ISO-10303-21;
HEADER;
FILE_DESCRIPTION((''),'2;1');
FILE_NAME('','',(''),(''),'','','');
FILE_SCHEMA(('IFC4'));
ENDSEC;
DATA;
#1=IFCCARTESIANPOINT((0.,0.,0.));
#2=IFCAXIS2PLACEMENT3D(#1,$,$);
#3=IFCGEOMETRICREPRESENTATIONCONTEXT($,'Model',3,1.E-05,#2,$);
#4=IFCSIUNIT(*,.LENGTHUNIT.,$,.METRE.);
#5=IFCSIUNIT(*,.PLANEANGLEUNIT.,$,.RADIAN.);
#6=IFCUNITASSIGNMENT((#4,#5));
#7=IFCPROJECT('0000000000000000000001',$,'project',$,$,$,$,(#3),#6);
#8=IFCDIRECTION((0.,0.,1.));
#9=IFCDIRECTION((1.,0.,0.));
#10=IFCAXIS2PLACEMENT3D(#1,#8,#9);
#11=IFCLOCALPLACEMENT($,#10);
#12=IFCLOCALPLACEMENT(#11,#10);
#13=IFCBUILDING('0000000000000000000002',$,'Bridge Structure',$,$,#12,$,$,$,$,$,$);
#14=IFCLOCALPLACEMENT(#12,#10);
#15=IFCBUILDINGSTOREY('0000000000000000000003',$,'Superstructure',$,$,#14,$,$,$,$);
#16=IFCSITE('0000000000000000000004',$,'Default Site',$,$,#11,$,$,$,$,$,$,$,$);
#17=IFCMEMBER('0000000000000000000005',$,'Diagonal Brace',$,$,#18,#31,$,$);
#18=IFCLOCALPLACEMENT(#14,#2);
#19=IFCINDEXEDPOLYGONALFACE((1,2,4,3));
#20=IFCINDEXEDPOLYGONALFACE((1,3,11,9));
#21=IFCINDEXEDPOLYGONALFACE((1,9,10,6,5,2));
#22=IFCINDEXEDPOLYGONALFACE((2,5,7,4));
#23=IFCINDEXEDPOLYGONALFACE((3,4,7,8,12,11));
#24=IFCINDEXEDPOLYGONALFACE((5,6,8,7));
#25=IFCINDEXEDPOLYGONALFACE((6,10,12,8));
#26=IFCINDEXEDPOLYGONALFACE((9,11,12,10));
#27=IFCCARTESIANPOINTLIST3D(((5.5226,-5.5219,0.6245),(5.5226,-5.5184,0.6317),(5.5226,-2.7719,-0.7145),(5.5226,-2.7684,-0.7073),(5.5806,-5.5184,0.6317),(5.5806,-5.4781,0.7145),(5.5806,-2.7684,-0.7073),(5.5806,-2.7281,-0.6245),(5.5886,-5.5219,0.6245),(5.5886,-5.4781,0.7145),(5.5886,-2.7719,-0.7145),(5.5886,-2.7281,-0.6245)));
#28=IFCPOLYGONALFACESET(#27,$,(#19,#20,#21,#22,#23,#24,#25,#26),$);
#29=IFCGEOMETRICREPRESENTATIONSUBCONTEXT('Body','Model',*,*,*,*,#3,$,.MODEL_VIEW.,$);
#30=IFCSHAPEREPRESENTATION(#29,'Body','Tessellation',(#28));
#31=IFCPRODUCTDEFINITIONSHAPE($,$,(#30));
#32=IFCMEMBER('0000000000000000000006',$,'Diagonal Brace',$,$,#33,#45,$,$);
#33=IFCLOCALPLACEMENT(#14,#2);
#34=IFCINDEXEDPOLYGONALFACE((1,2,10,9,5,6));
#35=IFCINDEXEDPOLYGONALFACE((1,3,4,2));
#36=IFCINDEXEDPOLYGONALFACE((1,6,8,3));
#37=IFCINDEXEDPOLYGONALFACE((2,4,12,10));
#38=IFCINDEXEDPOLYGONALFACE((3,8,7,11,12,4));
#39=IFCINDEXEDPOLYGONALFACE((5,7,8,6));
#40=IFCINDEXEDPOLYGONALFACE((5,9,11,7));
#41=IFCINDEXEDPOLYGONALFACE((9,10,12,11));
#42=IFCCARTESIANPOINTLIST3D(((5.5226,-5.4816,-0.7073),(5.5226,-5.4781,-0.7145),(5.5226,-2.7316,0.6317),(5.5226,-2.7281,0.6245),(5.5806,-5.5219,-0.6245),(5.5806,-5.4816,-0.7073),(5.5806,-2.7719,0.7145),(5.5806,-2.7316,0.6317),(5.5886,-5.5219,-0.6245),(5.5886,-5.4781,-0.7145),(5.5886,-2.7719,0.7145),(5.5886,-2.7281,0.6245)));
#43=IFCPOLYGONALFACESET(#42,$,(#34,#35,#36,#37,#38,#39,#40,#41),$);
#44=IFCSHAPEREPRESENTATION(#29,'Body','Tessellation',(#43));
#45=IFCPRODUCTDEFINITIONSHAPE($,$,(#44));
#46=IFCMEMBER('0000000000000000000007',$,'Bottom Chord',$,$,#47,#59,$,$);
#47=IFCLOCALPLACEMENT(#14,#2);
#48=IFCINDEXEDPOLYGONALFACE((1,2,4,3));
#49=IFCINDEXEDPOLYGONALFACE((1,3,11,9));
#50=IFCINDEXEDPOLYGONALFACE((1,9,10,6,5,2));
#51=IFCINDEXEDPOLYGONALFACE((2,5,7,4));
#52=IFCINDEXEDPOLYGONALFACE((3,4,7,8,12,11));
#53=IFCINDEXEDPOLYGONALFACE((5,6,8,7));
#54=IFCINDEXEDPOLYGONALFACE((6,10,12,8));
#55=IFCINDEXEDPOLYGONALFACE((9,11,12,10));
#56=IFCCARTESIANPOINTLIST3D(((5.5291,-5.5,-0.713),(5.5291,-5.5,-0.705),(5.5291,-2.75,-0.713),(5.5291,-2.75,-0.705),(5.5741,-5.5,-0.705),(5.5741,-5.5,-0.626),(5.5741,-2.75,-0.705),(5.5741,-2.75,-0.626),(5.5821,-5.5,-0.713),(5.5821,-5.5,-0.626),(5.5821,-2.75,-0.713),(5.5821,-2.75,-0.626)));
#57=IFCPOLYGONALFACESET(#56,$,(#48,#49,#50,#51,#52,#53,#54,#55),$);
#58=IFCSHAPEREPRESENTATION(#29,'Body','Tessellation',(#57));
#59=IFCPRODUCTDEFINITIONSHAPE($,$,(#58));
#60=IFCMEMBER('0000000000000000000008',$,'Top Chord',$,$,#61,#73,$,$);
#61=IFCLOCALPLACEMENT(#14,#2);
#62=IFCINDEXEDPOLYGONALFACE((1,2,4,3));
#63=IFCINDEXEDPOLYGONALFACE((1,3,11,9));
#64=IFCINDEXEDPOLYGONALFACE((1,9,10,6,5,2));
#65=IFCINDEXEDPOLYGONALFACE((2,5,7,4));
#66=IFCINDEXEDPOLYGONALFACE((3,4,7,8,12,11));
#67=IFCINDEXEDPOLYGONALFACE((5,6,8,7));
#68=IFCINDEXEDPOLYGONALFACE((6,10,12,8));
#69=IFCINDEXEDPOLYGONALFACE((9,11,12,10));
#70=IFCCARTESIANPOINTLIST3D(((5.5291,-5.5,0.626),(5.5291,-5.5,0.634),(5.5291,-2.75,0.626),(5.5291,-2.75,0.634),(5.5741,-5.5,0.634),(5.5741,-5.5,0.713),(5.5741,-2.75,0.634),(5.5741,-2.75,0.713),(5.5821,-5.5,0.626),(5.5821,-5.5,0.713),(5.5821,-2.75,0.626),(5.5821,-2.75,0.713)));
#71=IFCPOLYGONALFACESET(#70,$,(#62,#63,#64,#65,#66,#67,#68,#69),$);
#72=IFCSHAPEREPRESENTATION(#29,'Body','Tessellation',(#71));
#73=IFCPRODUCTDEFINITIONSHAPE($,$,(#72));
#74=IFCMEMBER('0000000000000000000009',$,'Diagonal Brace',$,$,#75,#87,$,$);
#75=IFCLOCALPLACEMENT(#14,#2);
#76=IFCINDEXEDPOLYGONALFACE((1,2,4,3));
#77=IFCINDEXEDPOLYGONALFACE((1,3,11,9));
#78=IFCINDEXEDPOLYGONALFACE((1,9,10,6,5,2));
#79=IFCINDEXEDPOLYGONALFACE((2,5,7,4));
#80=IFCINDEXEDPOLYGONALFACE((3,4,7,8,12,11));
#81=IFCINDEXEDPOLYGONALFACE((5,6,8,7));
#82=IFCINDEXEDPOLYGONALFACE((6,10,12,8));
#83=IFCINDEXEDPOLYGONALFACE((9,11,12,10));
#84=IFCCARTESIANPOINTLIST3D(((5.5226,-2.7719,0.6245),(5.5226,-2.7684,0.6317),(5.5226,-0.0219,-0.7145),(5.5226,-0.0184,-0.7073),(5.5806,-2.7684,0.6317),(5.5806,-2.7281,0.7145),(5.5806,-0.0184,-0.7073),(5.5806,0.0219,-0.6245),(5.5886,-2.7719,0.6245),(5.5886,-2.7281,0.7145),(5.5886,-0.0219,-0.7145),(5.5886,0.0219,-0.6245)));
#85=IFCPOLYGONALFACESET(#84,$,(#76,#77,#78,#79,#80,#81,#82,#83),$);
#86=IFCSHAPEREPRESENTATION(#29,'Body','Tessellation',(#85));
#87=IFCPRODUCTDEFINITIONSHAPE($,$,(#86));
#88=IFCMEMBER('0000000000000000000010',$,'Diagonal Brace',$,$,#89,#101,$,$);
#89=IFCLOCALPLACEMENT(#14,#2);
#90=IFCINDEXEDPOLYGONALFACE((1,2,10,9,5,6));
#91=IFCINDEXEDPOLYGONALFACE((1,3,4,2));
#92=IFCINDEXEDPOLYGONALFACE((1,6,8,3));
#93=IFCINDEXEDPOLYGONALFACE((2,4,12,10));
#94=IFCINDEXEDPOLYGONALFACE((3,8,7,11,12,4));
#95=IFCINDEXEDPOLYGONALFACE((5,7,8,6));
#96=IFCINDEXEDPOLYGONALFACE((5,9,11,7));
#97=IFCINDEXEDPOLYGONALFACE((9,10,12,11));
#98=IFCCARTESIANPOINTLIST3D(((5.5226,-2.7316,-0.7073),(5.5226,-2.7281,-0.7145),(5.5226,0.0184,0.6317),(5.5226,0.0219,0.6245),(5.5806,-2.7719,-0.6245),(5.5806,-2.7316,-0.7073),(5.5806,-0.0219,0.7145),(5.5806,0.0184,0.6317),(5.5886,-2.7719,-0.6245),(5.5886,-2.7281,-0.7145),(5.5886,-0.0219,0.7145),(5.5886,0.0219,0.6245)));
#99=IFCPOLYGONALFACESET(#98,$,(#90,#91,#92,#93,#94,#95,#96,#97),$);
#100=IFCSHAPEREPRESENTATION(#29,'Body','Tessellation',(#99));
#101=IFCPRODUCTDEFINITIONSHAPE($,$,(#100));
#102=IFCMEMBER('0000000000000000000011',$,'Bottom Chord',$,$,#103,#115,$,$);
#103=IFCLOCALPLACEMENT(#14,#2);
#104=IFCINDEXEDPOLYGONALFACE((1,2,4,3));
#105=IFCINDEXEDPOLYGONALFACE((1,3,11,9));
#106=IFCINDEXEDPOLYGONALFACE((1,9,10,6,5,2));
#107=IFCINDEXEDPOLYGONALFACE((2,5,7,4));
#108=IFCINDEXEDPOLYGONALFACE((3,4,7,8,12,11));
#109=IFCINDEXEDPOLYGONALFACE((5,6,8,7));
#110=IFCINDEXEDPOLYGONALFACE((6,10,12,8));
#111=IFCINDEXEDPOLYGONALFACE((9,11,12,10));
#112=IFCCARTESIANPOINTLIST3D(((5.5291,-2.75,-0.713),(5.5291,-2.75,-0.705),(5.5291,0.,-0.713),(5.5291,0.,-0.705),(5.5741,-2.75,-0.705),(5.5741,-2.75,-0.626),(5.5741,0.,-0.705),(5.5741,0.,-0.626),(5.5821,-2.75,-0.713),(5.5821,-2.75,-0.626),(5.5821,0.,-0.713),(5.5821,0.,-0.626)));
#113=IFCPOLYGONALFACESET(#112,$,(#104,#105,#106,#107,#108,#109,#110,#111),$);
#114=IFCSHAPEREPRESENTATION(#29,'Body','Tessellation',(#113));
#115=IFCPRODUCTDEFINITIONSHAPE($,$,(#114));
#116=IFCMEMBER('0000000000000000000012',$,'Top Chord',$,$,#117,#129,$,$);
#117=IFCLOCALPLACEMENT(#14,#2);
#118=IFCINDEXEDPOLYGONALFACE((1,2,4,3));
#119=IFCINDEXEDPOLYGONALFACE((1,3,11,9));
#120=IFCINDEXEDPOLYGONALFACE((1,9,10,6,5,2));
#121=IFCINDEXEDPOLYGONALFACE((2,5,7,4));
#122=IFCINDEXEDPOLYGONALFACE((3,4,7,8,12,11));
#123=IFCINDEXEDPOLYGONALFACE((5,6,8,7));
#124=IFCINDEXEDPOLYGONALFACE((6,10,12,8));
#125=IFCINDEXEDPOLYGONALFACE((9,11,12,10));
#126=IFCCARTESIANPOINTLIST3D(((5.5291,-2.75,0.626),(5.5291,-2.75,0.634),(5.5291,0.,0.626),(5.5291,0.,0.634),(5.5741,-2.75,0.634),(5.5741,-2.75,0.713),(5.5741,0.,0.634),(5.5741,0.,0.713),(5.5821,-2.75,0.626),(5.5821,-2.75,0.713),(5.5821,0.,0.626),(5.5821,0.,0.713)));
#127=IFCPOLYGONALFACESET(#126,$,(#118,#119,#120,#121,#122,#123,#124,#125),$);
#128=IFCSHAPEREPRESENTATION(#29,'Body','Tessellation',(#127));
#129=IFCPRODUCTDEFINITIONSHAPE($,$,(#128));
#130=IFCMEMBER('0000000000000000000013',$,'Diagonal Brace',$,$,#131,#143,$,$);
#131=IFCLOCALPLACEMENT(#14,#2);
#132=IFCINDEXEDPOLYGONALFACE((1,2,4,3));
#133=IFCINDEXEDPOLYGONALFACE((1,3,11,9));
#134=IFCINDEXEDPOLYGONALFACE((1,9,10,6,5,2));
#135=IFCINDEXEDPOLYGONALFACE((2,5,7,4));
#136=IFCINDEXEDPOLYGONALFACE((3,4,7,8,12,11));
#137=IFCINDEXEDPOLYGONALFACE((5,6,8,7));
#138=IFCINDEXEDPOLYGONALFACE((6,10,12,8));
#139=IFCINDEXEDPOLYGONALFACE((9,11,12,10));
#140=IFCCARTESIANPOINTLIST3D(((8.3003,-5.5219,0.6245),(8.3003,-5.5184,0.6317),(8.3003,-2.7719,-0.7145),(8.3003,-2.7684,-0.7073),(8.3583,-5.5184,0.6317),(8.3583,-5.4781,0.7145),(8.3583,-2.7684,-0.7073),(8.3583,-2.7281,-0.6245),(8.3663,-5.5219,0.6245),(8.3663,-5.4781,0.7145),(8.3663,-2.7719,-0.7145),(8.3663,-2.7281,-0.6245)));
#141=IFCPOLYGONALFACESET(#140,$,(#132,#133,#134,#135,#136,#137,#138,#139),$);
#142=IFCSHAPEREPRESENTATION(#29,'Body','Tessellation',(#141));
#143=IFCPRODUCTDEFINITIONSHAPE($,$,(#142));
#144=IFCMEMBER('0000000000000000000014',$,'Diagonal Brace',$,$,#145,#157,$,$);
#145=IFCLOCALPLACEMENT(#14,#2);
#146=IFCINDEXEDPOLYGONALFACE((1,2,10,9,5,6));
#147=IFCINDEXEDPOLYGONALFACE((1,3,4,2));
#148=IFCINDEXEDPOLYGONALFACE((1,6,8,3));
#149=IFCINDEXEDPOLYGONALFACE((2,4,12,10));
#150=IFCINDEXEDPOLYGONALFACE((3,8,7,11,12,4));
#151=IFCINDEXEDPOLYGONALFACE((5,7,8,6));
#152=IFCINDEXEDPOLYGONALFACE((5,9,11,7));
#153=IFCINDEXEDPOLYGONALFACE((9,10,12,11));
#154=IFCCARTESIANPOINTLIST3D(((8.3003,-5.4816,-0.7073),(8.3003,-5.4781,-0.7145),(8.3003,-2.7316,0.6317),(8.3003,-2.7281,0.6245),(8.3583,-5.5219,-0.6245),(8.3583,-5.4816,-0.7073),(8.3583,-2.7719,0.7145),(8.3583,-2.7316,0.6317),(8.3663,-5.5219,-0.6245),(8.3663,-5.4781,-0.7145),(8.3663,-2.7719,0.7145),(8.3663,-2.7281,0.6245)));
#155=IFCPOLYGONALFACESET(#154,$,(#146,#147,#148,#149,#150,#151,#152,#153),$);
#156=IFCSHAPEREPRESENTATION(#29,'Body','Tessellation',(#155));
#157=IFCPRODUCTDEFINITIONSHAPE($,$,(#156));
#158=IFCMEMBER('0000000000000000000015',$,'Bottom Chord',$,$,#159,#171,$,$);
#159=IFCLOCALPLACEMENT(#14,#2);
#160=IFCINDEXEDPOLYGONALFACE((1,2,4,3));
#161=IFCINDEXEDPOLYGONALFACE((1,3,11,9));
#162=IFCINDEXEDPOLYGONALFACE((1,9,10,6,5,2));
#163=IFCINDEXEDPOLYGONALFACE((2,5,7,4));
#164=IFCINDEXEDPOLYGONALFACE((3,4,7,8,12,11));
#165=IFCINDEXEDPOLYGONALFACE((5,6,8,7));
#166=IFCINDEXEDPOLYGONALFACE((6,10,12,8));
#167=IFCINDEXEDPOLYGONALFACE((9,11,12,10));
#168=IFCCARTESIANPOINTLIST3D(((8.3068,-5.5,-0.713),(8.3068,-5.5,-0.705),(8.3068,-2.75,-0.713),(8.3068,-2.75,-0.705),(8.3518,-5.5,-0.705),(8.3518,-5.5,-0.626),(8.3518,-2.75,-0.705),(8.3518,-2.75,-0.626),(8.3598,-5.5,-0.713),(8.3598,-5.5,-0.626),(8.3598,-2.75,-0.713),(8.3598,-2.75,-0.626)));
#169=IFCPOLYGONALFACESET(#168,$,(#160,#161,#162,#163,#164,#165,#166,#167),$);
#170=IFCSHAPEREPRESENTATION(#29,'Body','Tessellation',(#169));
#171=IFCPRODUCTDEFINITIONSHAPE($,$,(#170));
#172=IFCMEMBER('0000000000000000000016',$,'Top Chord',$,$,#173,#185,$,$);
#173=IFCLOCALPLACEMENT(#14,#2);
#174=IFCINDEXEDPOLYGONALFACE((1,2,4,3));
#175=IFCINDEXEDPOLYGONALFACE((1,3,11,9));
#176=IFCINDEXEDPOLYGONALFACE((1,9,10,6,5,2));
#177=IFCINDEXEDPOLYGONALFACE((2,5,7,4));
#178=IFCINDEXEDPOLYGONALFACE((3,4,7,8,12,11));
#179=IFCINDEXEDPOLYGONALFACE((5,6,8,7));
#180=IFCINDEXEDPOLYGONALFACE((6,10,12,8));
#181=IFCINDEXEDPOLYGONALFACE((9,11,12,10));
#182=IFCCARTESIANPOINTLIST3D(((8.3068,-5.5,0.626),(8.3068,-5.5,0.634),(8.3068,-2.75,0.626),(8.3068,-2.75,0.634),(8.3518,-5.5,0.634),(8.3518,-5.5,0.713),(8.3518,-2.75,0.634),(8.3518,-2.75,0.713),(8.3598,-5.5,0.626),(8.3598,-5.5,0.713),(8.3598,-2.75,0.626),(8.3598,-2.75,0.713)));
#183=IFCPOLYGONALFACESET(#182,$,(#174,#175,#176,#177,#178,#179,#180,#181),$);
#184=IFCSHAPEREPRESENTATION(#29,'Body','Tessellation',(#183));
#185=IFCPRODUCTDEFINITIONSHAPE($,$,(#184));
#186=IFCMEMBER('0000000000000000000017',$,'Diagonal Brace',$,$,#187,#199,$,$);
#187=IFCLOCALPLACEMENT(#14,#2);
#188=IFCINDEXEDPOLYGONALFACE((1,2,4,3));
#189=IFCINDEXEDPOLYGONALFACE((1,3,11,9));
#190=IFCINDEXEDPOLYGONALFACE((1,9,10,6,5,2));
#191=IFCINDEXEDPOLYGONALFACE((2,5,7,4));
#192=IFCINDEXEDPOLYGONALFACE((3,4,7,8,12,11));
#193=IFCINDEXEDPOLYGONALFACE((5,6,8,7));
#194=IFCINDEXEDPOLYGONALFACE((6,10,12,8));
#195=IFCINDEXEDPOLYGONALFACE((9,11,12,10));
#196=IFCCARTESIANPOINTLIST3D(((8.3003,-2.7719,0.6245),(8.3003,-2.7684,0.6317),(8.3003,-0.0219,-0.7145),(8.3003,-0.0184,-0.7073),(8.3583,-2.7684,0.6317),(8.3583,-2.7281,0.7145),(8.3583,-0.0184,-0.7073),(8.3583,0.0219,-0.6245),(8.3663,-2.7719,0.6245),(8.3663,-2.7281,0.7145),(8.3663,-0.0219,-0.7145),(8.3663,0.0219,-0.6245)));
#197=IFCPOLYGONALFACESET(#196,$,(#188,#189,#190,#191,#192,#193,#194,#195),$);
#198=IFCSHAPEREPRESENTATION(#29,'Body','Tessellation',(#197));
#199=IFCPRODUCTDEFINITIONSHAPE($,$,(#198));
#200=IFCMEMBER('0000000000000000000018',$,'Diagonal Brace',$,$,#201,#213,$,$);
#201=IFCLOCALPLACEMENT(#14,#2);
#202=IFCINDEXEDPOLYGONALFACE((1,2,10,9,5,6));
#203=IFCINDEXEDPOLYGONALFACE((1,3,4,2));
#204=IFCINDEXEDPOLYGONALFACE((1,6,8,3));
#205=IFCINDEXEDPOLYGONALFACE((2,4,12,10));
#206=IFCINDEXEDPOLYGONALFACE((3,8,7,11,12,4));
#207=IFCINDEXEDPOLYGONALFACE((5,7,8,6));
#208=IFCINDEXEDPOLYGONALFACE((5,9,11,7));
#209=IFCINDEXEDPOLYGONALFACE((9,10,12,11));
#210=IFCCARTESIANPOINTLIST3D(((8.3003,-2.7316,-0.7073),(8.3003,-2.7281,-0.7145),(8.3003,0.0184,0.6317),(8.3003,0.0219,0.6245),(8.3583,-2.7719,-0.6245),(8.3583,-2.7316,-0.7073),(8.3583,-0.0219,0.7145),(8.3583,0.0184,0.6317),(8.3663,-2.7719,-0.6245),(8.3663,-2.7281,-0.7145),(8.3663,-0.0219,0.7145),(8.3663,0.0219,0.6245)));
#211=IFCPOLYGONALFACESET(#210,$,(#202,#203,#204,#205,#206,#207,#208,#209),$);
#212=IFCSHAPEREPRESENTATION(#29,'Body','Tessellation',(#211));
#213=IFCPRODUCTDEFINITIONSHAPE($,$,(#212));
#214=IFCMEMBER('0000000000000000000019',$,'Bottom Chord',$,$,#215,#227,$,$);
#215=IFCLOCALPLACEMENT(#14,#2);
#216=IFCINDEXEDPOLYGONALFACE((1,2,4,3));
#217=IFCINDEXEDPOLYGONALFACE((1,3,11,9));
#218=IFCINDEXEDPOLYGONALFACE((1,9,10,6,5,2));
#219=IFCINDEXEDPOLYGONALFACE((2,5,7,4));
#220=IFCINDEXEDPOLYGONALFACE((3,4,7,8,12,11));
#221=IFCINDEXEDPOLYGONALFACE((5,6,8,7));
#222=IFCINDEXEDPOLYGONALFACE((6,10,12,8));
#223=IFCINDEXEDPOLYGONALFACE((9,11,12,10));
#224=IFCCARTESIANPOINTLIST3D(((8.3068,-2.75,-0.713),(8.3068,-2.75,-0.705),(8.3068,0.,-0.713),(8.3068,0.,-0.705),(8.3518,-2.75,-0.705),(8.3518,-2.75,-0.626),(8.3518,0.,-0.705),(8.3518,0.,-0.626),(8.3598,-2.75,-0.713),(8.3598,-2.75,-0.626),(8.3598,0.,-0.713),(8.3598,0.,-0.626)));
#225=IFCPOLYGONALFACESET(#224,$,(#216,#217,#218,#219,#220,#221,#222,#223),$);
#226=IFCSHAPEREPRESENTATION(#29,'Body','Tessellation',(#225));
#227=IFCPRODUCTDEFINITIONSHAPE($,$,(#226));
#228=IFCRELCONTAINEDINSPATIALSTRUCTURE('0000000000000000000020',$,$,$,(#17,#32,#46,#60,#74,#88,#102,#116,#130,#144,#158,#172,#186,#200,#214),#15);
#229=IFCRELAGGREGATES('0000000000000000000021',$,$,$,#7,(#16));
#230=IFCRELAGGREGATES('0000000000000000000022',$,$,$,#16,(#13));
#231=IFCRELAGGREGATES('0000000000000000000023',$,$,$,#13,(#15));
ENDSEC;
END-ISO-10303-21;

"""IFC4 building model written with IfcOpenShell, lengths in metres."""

from ifc_helpers import new_model, si_unit, frame, origin, origin_with_axes, origin_2d_with_axis, place, context, subcontext, project, spatial, l_section, extrude, element, save


model = new_model("IFC4")

# Units and contexts
model_context = context("Model", 3, precision=1e-05, world=origin())
body_context = subcontext(model_context, "Body", "Model", "MODEL_VIEW")
ifc_project = project(units=[si_unit("LENGTHUNIT", "METRE"), si_unit("PLANEANGLEUNIT", "RADIAN")], contexts=[model_context])

# Site, building, storey
site_placement = place(None, origin_with_axes())
site = spatial("IfcSite", under=ifc_project, at=site_placement, Name="Default Site")
building_placement = place(site_placement, origin_with_axes())
building = spatial("IfcBuilding", under=site, at=building_placement, Name="Bridge Structure")
storey_placement = place(building_placement, origin_with_axes())
storey = spatial("IfcBuildingStorey", under=building, at=storey_placement, Name="Superstructure")

# Members
for number, where, z_axis, x_axis, name in (
    (1, (5.5556, -5.5, 0.6695), (0.0, 0.899086, -0.437773), (-1.0, 0.0, 0.0), "Diagonal Brace"),
    (2, (5.5556, -5.5, -0.6695), (0.0, 0.899086, 0.437773), (-1.0, 0.0, 0.0), "Diagonal Brace"),
):
    element("IfcMember", number, at=place(storey_placement, frame(where, z_axis=z_axis, x_axis=x_axis)), inside=storey, Name=name, context=body_context, shape_type="SweptSolid", body=[
        extrude(l_section(Depth=0.1, Width=0.066, Thickness=0.008, at=origin_2d_with_axis()), origin_with_axes(), (0.0, 0.0, 1.0), 3.0587),
    ])
for number, where, z_axis, x_axis, name in (
    (3, (5.5556, -5.5, -0.6695), (0.0, 1.0, 0.0), (-1.0, 0.0, 0.0), "Bottom Chord"),
    (4, (5.5556, -5.5, 0.6695), (0.0, 1.0, 0.0), (-1.0, 0.0, 0.0), "Top Chord"),
):
    element("IfcMember", number, at=place(storey_placement, frame(where, z_axis=z_axis, x_axis=x_axis)), inside=storey, Name=name, context=body_context, shape_type="SweptSolid", body=[
        extrude(l_section(Depth=0.087, Width=0.053, Thickness=0.008, at=origin_2d_with_axis()), origin_with_axes(), (0.0, 0.0, 1.0), 2.75),
    ])
for number, where, z_axis, x_axis, name in (
    (5, (5.5556, -2.75, 0.6695), (0.0, 0.899086, -0.437773), (-1.0, 0.0, 0.0), "Diagonal Brace"),
    (6, (5.5556, -2.75, -0.6695), (0.0, 0.899086, 0.437773), (-1.0, 0.0, 0.0), "Diagonal Brace"),
):
    element("IfcMember", number, at=place(storey_placement, frame(where, z_axis=z_axis, x_axis=x_axis)), inside=storey, Name=name, context=body_context, shape_type="SweptSolid", body=[
        extrude(l_section(Depth=0.1, Width=0.066, Thickness=0.008, at=origin_2d_with_axis()), origin_with_axes(), (0.0, 0.0, 1.0), 3.0587),
    ])
for number, where, z_axis, x_axis, name in (
    (7, (5.5556, -2.75, -0.6695), (0.0, 1.0, 0.0), (-1.0, 0.0, 0.0), "Bottom Chord"),
    (8, (5.5556, -2.75, 0.6695), (0.0, 1.0, 0.0), (-1.0, 0.0, 0.0), "Top Chord"),
):
    element("IfcMember", number, at=place(storey_placement, frame(where, z_axis=z_axis, x_axis=x_axis)), inside=storey, Name=name, context=body_context, shape_type="SweptSolid", body=[
        extrude(l_section(Depth=0.087, Width=0.053, Thickness=0.008, at=origin_2d_with_axis()), origin_with_axes(), (0.0, 0.0, 1.0), 2.75),
    ])
for number, where, z_axis, x_axis, name in (
    (9, (8.3333, -5.5, 0.6695), (0.0, 0.899086, -0.437773), (-1.0, 0.0, 0.0), "Diagonal Brace"),
    (10, (8.3333, -5.5, -0.6695), (0.0, 0.899086, 0.437773), (-1.0, 0.0, 0.0), "Diagonal Brace"),
):
    element("IfcMember", number, at=place(storey_placement, frame(where, z_axis=z_axis, x_axis=x_axis)), inside=storey, Name=name, context=body_context, shape_type="SweptSolid", body=[
        extrude(l_section(Depth=0.1, Width=0.066, Thickness=0.008, at=origin_2d_with_axis()), origin_with_axes(), (0.0, 0.0, 1.0), 3.0587),
    ])
for number, where, z_axis, x_axis, name in (
    (11, (8.3333, -5.5, -0.6695), (0.0, 1.0, 0.0), (-1.0, 0.0, 0.0), "Bottom Chord"),
    (12, (8.3333, -5.5, 0.6695), (0.0, 1.0, 0.0), (-1.0, 0.0, 0.0), "Top Chord"),
):
    element("IfcMember", number, at=place(storey_placement, frame(where, z_axis=z_axis, x_axis=x_axis)), inside=storey, Name=name, context=body_context, shape_type="SweptSolid", body=[
        extrude(l_section(Depth=0.087, Width=0.053, Thickness=0.008, at=origin_2d_with_axis()), origin_with_axes(), (0.0, 0.0, 1.0), 2.75),
    ])
for number, where, z_axis, x_axis, name in (
    (13, (8.3333, -2.75, 0.6695), (0.0, 0.899086, -0.437773), (-1.0, 0.0, 0.0), "Diagonal Brace"),
    (14, (8.3333, -2.75, -0.6695), (0.0, 0.899086, 0.437773), (-1.0, 0.0, 0.0), "Diagonal Brace"),
):
    element("IfcMember", number, at=place(storey_placement, frame(where, z_axis=z_axis, x_axis=x_axis)), inside=storey, Name=name, context=body_context, shape_type="SweptSolid", body=[
        extrude(l_section(Depth=0.1, Width=0.066, Thickness=0.008, at=origin_2d_with_axis()), origin_with_axes(), (0.0, 0.0, 1.0), 3.0587),
    ])
for number, where, z_axis, x_axis, name in (
    (15, (8.3333, -2.75, -0.6695), (0.0, 1.0, 0.0), (-1.0, 0.0, 0.0), "Bottom Chord"),
):
    element("IfcMember", number, at=place(storey_placement, frame(where, z_axis=z_axis, x_axis=x_axis)), inside=storey, Name=name, context=body_context, shape_type="SweptSolid", body=[
        extrude(l_section(Depth=0.087, Width=0.053, Thickness=0.008, at=origin_2d_with_axis()), origin_with_axes(), (0.0, 0.0, 1.0), 2.75),
    ])

save(model, "model.ifc")
